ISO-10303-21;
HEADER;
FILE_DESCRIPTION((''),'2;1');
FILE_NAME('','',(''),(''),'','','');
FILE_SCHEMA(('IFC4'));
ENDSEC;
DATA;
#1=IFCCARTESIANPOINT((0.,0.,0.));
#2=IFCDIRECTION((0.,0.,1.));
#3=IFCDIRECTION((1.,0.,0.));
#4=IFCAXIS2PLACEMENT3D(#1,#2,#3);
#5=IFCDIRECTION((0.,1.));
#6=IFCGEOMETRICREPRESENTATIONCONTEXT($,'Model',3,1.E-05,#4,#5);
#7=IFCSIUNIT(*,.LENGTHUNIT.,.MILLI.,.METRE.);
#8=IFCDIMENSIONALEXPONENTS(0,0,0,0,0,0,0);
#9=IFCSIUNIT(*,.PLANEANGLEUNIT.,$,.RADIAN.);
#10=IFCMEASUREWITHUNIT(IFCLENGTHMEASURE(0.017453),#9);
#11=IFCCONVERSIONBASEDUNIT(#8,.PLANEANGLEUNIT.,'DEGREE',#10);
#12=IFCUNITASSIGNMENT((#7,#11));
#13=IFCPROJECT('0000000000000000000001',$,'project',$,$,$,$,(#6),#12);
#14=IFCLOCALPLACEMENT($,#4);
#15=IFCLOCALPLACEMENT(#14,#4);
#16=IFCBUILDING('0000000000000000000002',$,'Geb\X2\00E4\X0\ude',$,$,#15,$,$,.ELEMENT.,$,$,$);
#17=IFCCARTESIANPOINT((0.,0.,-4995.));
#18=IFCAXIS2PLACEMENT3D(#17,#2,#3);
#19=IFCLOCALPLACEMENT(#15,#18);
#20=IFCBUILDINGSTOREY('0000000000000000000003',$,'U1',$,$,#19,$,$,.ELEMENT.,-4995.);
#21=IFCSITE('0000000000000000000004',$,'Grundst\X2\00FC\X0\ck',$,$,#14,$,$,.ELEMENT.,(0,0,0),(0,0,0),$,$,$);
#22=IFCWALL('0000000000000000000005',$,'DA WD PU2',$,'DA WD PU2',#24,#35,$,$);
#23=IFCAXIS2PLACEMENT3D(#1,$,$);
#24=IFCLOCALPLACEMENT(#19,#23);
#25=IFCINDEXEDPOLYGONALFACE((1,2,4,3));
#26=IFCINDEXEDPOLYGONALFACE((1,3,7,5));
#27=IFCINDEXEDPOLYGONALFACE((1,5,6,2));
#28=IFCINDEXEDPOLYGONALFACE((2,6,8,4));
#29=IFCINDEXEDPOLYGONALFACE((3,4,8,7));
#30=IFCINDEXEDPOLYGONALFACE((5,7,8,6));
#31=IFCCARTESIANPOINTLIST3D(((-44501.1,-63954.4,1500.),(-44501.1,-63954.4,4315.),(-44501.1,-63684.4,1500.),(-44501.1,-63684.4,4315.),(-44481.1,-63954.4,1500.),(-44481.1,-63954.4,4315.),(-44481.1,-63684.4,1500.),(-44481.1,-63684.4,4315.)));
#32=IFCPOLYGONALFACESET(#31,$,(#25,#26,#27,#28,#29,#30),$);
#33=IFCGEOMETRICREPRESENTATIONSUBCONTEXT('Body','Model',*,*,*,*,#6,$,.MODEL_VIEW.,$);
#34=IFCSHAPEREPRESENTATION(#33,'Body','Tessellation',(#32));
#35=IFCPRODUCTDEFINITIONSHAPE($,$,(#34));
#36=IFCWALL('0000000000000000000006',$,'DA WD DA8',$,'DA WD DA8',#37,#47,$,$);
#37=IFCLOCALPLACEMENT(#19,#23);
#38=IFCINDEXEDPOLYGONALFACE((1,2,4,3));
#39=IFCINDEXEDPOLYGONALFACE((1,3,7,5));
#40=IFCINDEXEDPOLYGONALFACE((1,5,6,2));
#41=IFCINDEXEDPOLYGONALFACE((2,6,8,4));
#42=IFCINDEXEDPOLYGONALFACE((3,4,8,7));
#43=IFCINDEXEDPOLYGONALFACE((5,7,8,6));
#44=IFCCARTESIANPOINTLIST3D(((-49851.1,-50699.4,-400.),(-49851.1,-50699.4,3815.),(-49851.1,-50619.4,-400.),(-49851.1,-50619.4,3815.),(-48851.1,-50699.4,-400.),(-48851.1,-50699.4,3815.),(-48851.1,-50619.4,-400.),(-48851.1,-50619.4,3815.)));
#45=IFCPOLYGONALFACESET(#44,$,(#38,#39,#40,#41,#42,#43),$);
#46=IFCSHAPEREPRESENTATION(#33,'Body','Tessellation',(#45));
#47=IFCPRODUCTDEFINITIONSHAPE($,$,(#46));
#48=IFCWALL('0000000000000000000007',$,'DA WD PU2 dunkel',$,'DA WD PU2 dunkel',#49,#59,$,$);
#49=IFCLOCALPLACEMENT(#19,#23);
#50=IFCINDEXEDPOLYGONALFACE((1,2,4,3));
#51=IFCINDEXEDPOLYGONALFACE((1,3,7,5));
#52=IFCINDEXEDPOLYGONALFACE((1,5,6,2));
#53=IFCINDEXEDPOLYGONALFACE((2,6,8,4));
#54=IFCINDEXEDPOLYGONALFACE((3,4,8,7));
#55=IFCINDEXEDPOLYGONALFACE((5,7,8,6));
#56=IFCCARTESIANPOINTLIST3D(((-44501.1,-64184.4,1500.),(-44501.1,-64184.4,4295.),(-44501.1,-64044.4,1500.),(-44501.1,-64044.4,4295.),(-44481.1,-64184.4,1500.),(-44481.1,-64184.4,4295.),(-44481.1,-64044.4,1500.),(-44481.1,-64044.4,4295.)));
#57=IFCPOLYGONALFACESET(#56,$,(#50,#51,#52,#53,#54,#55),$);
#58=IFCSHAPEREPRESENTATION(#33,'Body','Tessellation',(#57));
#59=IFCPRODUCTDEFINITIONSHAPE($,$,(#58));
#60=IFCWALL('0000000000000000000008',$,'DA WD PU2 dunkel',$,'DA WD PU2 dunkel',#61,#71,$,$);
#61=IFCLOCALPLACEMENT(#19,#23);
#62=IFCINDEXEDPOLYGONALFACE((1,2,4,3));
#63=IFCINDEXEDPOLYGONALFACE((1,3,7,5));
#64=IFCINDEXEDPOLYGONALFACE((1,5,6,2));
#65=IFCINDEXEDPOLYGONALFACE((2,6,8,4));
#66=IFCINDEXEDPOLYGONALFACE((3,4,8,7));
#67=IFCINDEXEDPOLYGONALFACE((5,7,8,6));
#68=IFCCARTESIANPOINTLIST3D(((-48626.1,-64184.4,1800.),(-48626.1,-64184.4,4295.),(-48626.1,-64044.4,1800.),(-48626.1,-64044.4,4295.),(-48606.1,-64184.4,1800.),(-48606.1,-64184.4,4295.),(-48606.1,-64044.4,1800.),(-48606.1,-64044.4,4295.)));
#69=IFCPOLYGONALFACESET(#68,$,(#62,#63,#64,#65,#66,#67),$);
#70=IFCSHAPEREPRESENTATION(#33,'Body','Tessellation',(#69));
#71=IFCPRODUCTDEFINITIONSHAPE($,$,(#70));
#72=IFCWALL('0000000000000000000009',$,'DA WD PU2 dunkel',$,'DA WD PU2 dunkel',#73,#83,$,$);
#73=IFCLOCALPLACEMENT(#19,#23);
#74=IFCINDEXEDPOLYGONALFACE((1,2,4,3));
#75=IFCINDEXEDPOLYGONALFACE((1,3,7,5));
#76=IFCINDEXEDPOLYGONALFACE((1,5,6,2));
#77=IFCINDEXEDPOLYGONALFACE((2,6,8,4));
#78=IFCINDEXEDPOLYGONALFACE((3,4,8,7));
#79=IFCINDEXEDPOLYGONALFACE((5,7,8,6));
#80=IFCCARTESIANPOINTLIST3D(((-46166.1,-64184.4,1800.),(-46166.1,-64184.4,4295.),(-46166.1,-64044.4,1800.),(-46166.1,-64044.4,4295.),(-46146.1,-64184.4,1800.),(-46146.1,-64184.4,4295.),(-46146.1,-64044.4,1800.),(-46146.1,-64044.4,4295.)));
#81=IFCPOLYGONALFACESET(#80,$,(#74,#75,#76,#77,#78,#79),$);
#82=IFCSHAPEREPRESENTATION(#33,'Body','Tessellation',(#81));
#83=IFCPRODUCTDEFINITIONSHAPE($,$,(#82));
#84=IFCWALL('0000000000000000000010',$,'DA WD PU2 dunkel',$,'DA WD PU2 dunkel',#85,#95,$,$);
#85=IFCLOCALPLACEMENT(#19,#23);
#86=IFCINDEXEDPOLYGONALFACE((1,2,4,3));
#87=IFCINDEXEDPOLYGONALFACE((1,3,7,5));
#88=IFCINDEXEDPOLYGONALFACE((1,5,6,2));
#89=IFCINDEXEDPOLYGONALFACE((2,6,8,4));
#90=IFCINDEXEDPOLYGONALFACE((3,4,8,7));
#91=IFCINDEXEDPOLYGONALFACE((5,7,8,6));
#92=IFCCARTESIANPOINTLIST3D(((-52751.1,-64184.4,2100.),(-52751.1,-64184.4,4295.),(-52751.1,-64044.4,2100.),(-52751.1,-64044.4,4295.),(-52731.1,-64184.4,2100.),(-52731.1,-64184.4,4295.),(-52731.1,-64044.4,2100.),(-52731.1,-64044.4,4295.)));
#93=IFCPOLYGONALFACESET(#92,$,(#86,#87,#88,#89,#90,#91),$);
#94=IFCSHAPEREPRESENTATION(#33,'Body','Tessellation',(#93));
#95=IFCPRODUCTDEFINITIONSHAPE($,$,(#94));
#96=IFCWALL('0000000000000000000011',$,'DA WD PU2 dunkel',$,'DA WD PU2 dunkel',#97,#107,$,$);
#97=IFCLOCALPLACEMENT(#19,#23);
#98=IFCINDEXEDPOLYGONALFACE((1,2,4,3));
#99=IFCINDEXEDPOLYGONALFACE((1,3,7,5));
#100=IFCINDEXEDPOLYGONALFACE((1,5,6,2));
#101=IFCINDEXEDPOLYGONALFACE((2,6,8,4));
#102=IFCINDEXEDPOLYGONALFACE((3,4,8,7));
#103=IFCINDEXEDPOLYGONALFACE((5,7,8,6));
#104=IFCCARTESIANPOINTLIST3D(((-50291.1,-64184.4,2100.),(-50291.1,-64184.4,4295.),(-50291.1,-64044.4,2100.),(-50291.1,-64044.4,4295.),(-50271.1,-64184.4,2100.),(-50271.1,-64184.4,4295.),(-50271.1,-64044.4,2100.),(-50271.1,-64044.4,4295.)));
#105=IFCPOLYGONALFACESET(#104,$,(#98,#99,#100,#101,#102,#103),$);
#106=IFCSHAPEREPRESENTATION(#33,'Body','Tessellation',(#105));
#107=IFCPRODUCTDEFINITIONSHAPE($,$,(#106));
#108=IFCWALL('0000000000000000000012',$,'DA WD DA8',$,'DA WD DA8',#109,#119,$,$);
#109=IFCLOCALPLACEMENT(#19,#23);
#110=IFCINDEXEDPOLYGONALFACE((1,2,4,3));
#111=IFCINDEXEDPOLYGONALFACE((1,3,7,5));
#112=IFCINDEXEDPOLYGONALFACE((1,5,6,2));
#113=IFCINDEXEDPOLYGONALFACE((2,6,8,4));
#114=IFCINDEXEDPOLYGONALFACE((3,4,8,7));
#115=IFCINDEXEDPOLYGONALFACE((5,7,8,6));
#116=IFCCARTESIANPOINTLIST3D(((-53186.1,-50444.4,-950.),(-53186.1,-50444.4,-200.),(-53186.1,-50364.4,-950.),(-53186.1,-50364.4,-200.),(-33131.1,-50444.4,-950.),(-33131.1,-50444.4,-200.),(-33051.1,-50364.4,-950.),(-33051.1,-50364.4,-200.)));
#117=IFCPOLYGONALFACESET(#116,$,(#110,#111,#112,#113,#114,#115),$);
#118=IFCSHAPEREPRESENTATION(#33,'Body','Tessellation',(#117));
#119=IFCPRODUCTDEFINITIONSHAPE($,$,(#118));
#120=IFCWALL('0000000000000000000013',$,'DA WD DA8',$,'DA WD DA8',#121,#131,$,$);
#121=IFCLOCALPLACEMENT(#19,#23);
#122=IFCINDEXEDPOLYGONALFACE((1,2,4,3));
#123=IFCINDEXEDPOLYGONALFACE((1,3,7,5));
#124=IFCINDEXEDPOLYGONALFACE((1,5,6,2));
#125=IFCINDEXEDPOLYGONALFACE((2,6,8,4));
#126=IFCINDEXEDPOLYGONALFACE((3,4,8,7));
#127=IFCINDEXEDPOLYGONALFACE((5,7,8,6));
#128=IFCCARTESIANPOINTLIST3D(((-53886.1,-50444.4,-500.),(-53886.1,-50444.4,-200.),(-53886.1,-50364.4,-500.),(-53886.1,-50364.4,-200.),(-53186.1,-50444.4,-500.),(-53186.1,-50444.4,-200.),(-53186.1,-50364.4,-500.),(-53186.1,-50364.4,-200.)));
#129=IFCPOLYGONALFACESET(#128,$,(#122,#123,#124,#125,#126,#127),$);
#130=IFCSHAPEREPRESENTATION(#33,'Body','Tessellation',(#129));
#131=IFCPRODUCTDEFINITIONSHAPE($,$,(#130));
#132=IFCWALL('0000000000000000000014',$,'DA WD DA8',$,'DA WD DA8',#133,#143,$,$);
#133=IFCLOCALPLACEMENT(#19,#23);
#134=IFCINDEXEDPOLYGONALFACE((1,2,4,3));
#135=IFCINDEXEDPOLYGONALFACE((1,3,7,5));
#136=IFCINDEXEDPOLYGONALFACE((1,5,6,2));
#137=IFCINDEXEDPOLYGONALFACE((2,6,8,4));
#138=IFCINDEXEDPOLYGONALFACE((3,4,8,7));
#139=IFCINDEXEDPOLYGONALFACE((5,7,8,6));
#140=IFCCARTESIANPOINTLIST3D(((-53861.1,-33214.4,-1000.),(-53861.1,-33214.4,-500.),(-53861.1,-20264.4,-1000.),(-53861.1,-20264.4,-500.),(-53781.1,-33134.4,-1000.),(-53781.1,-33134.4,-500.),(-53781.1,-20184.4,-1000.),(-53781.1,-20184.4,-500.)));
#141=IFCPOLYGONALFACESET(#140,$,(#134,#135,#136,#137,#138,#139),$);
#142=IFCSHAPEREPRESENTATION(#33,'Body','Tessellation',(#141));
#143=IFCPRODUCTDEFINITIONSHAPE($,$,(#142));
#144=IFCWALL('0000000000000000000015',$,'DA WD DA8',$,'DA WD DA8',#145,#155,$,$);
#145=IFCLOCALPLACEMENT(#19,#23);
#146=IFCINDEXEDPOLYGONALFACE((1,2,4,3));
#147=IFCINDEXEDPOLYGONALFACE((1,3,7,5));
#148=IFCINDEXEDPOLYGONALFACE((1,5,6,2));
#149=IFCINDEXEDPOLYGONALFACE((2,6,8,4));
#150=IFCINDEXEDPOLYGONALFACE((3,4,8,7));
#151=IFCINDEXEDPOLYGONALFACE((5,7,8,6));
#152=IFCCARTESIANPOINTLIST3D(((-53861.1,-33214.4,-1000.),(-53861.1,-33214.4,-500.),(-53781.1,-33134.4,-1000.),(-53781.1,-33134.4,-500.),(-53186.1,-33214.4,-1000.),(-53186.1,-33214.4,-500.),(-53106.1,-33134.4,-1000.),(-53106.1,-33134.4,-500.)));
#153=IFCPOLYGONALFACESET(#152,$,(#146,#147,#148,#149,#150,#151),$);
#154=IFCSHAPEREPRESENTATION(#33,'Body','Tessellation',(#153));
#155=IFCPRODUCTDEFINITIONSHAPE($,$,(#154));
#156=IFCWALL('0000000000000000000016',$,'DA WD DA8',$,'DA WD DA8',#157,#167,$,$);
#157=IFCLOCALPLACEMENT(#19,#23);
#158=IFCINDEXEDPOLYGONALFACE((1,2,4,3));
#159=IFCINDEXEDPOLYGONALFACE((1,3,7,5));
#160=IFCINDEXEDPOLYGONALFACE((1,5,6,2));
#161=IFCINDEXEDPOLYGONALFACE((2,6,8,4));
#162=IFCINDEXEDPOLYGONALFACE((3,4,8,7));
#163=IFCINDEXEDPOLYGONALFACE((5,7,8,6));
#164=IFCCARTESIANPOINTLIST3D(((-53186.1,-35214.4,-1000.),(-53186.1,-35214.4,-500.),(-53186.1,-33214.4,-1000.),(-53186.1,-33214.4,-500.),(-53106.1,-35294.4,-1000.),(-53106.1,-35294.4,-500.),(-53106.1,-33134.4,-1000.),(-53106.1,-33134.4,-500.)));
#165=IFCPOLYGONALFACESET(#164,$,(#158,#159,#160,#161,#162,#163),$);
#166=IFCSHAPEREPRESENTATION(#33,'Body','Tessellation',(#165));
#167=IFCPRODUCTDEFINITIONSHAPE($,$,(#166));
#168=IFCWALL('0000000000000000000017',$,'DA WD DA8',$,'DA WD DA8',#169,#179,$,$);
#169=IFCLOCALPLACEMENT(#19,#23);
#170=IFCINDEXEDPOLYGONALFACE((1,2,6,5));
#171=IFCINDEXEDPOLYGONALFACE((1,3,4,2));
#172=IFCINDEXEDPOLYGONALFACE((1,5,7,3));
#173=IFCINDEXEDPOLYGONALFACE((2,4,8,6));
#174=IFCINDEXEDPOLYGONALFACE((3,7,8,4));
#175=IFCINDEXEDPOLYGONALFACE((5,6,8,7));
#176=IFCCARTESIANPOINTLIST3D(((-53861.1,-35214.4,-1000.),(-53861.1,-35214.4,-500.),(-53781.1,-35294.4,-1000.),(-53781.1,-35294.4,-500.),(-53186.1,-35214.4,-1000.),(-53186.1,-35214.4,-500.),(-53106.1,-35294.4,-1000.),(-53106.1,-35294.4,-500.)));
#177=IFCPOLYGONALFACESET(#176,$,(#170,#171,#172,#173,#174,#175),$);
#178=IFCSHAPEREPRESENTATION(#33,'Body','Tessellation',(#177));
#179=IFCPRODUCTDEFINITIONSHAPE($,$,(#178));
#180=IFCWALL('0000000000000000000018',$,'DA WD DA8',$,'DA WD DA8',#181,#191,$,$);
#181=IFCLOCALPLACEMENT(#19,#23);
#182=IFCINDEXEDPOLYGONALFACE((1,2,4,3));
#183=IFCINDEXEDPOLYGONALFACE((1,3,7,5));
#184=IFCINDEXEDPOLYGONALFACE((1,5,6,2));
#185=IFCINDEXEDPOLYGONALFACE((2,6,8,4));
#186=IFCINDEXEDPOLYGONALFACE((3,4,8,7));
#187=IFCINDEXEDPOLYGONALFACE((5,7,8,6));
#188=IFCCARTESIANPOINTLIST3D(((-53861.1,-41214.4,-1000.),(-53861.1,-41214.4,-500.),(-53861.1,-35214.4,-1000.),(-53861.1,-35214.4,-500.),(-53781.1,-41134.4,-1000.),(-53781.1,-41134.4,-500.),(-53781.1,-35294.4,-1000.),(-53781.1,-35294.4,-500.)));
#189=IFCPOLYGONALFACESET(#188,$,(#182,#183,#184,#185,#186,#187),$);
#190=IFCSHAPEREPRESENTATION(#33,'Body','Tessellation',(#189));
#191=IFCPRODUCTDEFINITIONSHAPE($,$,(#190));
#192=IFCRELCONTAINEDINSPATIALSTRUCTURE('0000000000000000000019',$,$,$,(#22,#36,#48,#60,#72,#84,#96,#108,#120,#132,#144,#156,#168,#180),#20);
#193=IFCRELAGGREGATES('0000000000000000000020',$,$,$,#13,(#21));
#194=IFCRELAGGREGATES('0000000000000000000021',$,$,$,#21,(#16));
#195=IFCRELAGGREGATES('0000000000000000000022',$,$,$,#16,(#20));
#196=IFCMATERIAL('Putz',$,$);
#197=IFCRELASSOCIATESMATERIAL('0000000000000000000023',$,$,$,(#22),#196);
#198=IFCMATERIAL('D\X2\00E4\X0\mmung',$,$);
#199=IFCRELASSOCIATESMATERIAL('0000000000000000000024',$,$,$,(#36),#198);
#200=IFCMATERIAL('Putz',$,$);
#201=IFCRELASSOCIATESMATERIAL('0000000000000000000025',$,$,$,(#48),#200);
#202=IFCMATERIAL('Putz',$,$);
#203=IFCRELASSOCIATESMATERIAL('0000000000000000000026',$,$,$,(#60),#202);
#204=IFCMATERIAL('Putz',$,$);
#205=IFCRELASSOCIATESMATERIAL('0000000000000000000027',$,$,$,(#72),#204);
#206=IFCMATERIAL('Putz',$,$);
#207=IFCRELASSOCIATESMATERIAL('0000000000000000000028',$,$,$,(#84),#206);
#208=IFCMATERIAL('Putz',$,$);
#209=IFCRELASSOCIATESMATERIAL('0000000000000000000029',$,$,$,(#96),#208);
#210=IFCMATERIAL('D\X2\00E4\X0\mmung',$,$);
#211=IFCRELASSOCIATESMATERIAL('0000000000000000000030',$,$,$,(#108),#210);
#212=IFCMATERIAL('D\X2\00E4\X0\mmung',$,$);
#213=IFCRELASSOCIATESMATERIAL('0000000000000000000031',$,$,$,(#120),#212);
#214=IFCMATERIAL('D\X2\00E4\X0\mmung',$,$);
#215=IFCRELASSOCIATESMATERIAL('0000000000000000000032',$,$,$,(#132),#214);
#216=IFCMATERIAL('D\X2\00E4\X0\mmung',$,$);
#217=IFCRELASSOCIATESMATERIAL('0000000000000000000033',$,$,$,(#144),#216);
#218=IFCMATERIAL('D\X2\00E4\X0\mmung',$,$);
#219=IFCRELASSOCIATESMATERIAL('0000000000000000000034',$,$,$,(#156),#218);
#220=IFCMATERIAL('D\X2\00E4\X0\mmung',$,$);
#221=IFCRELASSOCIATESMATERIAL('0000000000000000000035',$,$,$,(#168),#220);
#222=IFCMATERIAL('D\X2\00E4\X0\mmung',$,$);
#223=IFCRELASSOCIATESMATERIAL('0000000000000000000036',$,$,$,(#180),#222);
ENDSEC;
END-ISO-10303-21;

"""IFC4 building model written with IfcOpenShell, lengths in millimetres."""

from ifc_helpers import new_model, entity, si_unit, converted_unit, direction, frame, origin_with_axes, place, context, subcontext, project, spatial, line, indexed_curve, outline, extrude, material, element, save


model = new_model("IFC4")

# Units and contexts
model_context = context("Model", 3, precision=1e-05, world=origin_with_axes(), true_north=direction((0.0, 1.0)))
body_context = subcontext(model_context, "Body", "Model", "MODEL_VIEW")
ifc_project = project(units=[si_unit("LENGTHUNIT", "METRE", prefix="MILLI"), converted_unit("PLANEANGLEUNIT", "DEGREE", entity("IfcLengthMeasure", 0.017453), si_unit("PLANEANGLEUNIT", "RADIAN"), dimensions=[0, 0, 0, 0, 0, 0, 0])], contexts=[model_context])

# Site, building, storey
site_placement = place(None, origin_with_axes())
site = spatial("IfcSite", under=ifc_project, at=site_placement, Name="Grundstück", CompositionType="ELEMENT", RefLatitude=(0, 0, 0), RefLongitude=(0, 0, 0))
building_placement = place(site_placement, origin_with_axes())
building = spatial("IfcBuilding", under=site, at=building_placement, Name="Gebäude", CompositionType="ELEMENT")
storey_placement = place(building_placement, frame((0.0, 0.0, -4995.0), z_axis=(0.0, 0.0, 1.0), x_axis=(1.0, 0.0, 0.0)))
storey = spatial("IfcBuildingStorey", under=building, at=storey_placement, Name="U1", CompositionType="ELEMENT", Elevation=-4995.0)

# Walls
ifc_material_1 = material(Name="Putz")
wall_1_placement = place(storey_placement, frame((-44491.1, -63954.4, 1500.0), z_axis=(0.0, 0.0, 1.0), x_axis=(0.0, 1.0, 0.0)))
element("IfcWall", 1, at=wall_1_placement, inside=storey, material=ifc_material_1, Name="DA WD PU2", ObjectType="DA WD PU2", context=body_context, shape_type="SweptSolid", body=[
    extrude(outline(indexed_curve([(0.0, -10.0), (0.0, 10.0), (270.0, 10.0), (270.0, -10.0)], segments=[line(1, 2), line(2, 3), line(3, 4), line(4, 1)])), origin_with_axes(), (0.0, 0.0, 1.0), 2815.0),
])
ifc_material_2 = material(Name="Dämmung")
wall_2_placement = place(storey_placement, frame((-49851.1, -50659.4, -400.0), z_axis=(0.0, 0.0, 1.0), x_axis=(1.0, 0.0, 0.0)))
element("IfcWall", 2, at=wall_2_placement, inside=storey, material=ifc_material_2, Name="DA WD DA8", ObjectType="DA WD DA8", context=body_context, shape_type="SweptSolid", body=[
    extrude(outline(indexed_curve([(0.0, -40.0), (0.0, 40.0), (1000.0, 40.0), (1000.0, -40.0)], segments=[line(1, 2), line(2, 3), line(3, 4), line(4, 1)])), origin_with_axes(), (0.0, 0.0, 1.0), 4215.0),
])
ifc_material_3 = material(Name="Putz")
wall_3_placement = place(storey_placement, frame((-44491.1, -64184.4, 1500.0), z_axis=(0.0, 0.0, 1.0), x_axis=(0.0, 1.0, 0.0)))
element("IfcWall", 3, at=wall_3_placement, inside=storey, material=ifc_material_3, Name="DA WD PU2 dunkel", ObjectType="DA WD PU2 dunkel", context=body_context, shape_type="SweptSolid", body=[
    extrude(outline(indexed_curve([(0.0, -10.0), (0.0, 10.0), (140.0, 10.0), (140.0, -10.0)], segments=[line(1, 2), line(2, 3), line(3, 4), line(4, 1)])), origin_with_axes(), (0.0, 0.0, 1.0), 2795.0),
])
ifc_material_4 = material(Name="Putz")
wall_4_placement = place(storey_placement, frame((-48616.1, -64184.4, 1800.0), z_axis=(0.0, 0.0, 1.0), x_axis=(0.0, 1.0, 0.0)))
element("IfcWall", 4, at=wall_4_placement, inside=storey, material=ifc_material_4, Name="DA WD PU2 dunkel", ObjectType="DA WD PU2 dunkel", context=body_context, shape_type="SweptSolid", body=[
    extrude(outline(indexed_curve([(0.0, -10.0), (0.0, 10.0), (140.0, 10.0), (140.0, -10.0)], segments=[line(1, 2), line(2, 3), line(3, 4), line(4, 1)])), origin_with_axes(), (0.0, 0.0, 1.0), 2495.0),
])
ifc_material_5 = material(Name="Putz")
wall_5_placement = place(storey_placement, frame((-46156.1, -64184.4, 1800.0), z_axis=(0.0, 0.0, 1.0), x_axis=(0.0, 1.0, 0.0)))
element("IfcWall", 5, at=wall_5_placement, inside=storey, material=ifc_material_5, Name="DA WD PU2 dunkel", ObjectType="DA WD PU2 dunkel", context=body_context, shape_type="SweptSolid", body=[
    extrude(outline(indexed_curve([(0.0, -10.0), (0.0, 10.0), (140.0, 10.0), (140.0, -10.0)], segments=[line(1, 2), line(2, 3), line(3, 4), line(4, 1)])), origin_with_axes(), (0.0, 0.0, 1.0), 2495.0),
])
ifc_material_6 = material(Name="Putz")
wall_6_placement = place(storey_placement, frame((-52741.1, -64184.4, 2100.0), z_axis=(0.0, 0.0, 1.0), x_axis=(0.0, 1.0, 0.0)))
element("IfcWall", 6, at=wall_6_placement, inside=storey, material=ifc_material_6, Name="DA WD PU2 dunkel", ObjectType="DA WD PU2 dunkel", context=body_context, shape_type="SweptSolid", body=[
    extrude(outline(indexed_curve([(0.0, -10.0), (0.0, 10.0), (140.0, 10.0), (140.0, -10.0)], segments=[line(1, 2), line(2, 3), line(3, 4), line(4, 1)])), origin_with_axes(), (0.0, 0.0, 1.0), 2195.0),
])
ifc_material_7 = material(Name="Putz")
wall_7_placement = place(storey_placement, frame((-50281.1, -64184.4, 2100.0), z_axis=(0.0, 0.0, 1.0), x_axis=(0.0, 1.0, 0.0)))
element("IfcWall", 7, at=wall_7_placement, inside=storey, material=ifc_material_7, Name="DA WD PU2 dunkel", ObjectType="DA WD PU2 dunkel", context=body_context, shape_type="SweptSolid", body=[
    extrude(outline(indexed_curve([(0.0, -10.0), (0.0, 10.0), (140.0, 10.0), (140.0, -10.0)], segments=[line(1, 2), line(2, 3), line(3, 4), line(4, 1)])), origin_with_axes(), (0.0, 0.0, 1.0), 2195.0),
])
ifc_material_8 = material(Name="Dämmung")
wall_8_placement = place(storey_placement, frame((-53186.1, -50404.4, -950.0), z_axis=(0.0, 0.0, 1.0), x_axis=(1.0, 0.0, 0.0)))
element("IfcWall", 8, at=wall_8_placement, inside=storey, material=ifc_material_8, Name="DA WD DA8", ObjectType="DA WD DA8", context=body_context, shape_type="SweptSolid", body=[
    extrude(outline(indexed_curve([(0.0, -40.0), (0.0, 40.0), (20135.0, 40.0), (20055.0, -40.0)], segments=[line(1, 2), line(2, 3), line(3, 4), line(4, 1)])), origin_with_axes(), (0.0, 0.0, 1.0), 750.0),
])
ifc_material_9 = material(Name="Dämmung")
wall_9_placement = place(storey_placement, frame((-53886.1, -50404.4, -500.0), z_axis=(0.0, 0.0, 1.0), x_axis=(1.0, 0.0, 0.0)))
element("IfcWall", 9, at=wall_9_placement, inside=storey, material=ifc_material_9, Name="DA WD DA8", ObjectType="DA WD DA8", context=body_context, shape_type="SweptSolid", body=[
    extrude(outline(indexed_curve([(0.0, -40.0), (0.0, 40.0), (700.0, 40.0), (700.0, -40.0)], segments=[line(1, 2), line(2, 3), line(3, 4), line(4, 1)])), origin_with_axes(), (0.0, 0.0, 1.0), 300.0),
])
ifc_material_10 = material(Name="Dämmung")
wall_10_placement = place(storey_placement, frame((-53821.1, -20224.4, -1000.0), z_axis=(0.0, 0.0, 1.0), x_axis=(0.0, -1.0, 0.0)))
element("IfcWall", 10, at=wall_10_placement, inside=storey, material=ifc_material_10, Name="DA WD DA8", ObjectType="DA WD DA8", context=body_context, shape_type="SweptSolid", body=[
    extrude(outline(indexed_curve([(40.0, -40.0), (-40.0, 40.0), (12910.0, 40.0), (12990.0, -40.0)], segments=[line(1, 2), line(2, 3), line(3, 4), line(4, 1)])), origin_with_axes(), (0.0, 0.0, 1.0), 500.0),
])
ifc_material_11 = material(Name="Dämmung")
wall_11_placement = place(storey_placement, frame((-53821.1, -33174.4, -1000.0), z_axis=(0.0, 0.0, 1.0), x_axis=(1.0, 0.0, 0.0)))
element("IfcWall", 11, at=wall_11_placement, inside=storey, material=ifc_material_11, Name="DA WD DA8", ObjectType="DA WD DA8", context=body_context, shape_type="SweptSolid", body=[
    extrude(outline(indexed_curve([(-40.0, -40.0), (40.0, 40.0), (715.0, 40.0), (635.0, -40.0)], segments=[line(1, 2), line(2, 3), line(3, 4), line(4, 1)])), origin_with_axes(), (0.0, 0.0, 1.0), 500.0),
])
ifc_material_12 = material(Name="Dämmung")
wall_12_placement = place(storey_placement, frame((-53146.1, -33174.4, -1000.0), z_axis=(0.0, 0.0, 1.0), x_axis=(0.0, -1.0, 0.0)))
element("IfcWall", 12, at=wall_12_placement, inside=storey, material=ifc_material_12, Name="DA WD DA8", ObjectType="DA WD DA8", context=body_context, shape_type="SweptSolid", body=[
    extrude(outline(indexed_curve([(40.0, -40.0), (-40.0, 40.0), (2120.0, 40.0), (2040.0, -40.0)], segments=[line(1, 2), line(2, 3), line(3, 4), line(4, 1)])), origin_with_axes(), (0.0, 0.0, 1.0), 500.0),
])
ifc_material_13 = material(Name="Dämmung")
wall_13_placement = place(storey_placement, frame((-53146.1, -35254.4, -1000.0), z_axis=(0.0, 0.0, 1.0), x_axis=(-1.0, 0.0, 0.0)))
element("IfcWall", 13, at=wall_13_placement, inside=storey, material=ifc_material_13, Name="DA WD DA8", ObjectType="DA WD DA8", context=body_context, shape_type="SweptSolid", body=[
    extrude(outline(indexed_curve([(40.0, -40.0), (-40.0, 40.0), (635.0, 40.0), (715.0, -40.0)], segments=[line(1, 2), line(2, 3), line(3, 4), line(4, 1)])), origin_with_axes(), (0.0, 0.0, 1.0), 500.0),
])
ifc_material_14 = material(Name="Dämmung")
wall_14_placement = place(storey_placement, frame((-53821.1, -35254.4, -1000.0), z_axis=(0.0, 0.0, 1.0), x_axis=(0.0, -1.0, 0.0)))
element("IfcWall", 14, at=wall_14_placement, inside=storey, material=ifc_material_14, Name="DA WD DA8", ObjectType="DA WD DA8", context=body_context, shape_type="SweptSolid", body=[
    extrude(outline(indexed_curve([(-40.0, -40.0), (40.0, 40.0), (5880.0, 40.0), (5960.0, -40.0)], segments=[line(1, 2), line(2, 3), line(3, 4), line(4, 1)])), origin_with_axes(), (0.0, 0.0, 1.0), 500.0),
])

save(model, "model.ifc")
